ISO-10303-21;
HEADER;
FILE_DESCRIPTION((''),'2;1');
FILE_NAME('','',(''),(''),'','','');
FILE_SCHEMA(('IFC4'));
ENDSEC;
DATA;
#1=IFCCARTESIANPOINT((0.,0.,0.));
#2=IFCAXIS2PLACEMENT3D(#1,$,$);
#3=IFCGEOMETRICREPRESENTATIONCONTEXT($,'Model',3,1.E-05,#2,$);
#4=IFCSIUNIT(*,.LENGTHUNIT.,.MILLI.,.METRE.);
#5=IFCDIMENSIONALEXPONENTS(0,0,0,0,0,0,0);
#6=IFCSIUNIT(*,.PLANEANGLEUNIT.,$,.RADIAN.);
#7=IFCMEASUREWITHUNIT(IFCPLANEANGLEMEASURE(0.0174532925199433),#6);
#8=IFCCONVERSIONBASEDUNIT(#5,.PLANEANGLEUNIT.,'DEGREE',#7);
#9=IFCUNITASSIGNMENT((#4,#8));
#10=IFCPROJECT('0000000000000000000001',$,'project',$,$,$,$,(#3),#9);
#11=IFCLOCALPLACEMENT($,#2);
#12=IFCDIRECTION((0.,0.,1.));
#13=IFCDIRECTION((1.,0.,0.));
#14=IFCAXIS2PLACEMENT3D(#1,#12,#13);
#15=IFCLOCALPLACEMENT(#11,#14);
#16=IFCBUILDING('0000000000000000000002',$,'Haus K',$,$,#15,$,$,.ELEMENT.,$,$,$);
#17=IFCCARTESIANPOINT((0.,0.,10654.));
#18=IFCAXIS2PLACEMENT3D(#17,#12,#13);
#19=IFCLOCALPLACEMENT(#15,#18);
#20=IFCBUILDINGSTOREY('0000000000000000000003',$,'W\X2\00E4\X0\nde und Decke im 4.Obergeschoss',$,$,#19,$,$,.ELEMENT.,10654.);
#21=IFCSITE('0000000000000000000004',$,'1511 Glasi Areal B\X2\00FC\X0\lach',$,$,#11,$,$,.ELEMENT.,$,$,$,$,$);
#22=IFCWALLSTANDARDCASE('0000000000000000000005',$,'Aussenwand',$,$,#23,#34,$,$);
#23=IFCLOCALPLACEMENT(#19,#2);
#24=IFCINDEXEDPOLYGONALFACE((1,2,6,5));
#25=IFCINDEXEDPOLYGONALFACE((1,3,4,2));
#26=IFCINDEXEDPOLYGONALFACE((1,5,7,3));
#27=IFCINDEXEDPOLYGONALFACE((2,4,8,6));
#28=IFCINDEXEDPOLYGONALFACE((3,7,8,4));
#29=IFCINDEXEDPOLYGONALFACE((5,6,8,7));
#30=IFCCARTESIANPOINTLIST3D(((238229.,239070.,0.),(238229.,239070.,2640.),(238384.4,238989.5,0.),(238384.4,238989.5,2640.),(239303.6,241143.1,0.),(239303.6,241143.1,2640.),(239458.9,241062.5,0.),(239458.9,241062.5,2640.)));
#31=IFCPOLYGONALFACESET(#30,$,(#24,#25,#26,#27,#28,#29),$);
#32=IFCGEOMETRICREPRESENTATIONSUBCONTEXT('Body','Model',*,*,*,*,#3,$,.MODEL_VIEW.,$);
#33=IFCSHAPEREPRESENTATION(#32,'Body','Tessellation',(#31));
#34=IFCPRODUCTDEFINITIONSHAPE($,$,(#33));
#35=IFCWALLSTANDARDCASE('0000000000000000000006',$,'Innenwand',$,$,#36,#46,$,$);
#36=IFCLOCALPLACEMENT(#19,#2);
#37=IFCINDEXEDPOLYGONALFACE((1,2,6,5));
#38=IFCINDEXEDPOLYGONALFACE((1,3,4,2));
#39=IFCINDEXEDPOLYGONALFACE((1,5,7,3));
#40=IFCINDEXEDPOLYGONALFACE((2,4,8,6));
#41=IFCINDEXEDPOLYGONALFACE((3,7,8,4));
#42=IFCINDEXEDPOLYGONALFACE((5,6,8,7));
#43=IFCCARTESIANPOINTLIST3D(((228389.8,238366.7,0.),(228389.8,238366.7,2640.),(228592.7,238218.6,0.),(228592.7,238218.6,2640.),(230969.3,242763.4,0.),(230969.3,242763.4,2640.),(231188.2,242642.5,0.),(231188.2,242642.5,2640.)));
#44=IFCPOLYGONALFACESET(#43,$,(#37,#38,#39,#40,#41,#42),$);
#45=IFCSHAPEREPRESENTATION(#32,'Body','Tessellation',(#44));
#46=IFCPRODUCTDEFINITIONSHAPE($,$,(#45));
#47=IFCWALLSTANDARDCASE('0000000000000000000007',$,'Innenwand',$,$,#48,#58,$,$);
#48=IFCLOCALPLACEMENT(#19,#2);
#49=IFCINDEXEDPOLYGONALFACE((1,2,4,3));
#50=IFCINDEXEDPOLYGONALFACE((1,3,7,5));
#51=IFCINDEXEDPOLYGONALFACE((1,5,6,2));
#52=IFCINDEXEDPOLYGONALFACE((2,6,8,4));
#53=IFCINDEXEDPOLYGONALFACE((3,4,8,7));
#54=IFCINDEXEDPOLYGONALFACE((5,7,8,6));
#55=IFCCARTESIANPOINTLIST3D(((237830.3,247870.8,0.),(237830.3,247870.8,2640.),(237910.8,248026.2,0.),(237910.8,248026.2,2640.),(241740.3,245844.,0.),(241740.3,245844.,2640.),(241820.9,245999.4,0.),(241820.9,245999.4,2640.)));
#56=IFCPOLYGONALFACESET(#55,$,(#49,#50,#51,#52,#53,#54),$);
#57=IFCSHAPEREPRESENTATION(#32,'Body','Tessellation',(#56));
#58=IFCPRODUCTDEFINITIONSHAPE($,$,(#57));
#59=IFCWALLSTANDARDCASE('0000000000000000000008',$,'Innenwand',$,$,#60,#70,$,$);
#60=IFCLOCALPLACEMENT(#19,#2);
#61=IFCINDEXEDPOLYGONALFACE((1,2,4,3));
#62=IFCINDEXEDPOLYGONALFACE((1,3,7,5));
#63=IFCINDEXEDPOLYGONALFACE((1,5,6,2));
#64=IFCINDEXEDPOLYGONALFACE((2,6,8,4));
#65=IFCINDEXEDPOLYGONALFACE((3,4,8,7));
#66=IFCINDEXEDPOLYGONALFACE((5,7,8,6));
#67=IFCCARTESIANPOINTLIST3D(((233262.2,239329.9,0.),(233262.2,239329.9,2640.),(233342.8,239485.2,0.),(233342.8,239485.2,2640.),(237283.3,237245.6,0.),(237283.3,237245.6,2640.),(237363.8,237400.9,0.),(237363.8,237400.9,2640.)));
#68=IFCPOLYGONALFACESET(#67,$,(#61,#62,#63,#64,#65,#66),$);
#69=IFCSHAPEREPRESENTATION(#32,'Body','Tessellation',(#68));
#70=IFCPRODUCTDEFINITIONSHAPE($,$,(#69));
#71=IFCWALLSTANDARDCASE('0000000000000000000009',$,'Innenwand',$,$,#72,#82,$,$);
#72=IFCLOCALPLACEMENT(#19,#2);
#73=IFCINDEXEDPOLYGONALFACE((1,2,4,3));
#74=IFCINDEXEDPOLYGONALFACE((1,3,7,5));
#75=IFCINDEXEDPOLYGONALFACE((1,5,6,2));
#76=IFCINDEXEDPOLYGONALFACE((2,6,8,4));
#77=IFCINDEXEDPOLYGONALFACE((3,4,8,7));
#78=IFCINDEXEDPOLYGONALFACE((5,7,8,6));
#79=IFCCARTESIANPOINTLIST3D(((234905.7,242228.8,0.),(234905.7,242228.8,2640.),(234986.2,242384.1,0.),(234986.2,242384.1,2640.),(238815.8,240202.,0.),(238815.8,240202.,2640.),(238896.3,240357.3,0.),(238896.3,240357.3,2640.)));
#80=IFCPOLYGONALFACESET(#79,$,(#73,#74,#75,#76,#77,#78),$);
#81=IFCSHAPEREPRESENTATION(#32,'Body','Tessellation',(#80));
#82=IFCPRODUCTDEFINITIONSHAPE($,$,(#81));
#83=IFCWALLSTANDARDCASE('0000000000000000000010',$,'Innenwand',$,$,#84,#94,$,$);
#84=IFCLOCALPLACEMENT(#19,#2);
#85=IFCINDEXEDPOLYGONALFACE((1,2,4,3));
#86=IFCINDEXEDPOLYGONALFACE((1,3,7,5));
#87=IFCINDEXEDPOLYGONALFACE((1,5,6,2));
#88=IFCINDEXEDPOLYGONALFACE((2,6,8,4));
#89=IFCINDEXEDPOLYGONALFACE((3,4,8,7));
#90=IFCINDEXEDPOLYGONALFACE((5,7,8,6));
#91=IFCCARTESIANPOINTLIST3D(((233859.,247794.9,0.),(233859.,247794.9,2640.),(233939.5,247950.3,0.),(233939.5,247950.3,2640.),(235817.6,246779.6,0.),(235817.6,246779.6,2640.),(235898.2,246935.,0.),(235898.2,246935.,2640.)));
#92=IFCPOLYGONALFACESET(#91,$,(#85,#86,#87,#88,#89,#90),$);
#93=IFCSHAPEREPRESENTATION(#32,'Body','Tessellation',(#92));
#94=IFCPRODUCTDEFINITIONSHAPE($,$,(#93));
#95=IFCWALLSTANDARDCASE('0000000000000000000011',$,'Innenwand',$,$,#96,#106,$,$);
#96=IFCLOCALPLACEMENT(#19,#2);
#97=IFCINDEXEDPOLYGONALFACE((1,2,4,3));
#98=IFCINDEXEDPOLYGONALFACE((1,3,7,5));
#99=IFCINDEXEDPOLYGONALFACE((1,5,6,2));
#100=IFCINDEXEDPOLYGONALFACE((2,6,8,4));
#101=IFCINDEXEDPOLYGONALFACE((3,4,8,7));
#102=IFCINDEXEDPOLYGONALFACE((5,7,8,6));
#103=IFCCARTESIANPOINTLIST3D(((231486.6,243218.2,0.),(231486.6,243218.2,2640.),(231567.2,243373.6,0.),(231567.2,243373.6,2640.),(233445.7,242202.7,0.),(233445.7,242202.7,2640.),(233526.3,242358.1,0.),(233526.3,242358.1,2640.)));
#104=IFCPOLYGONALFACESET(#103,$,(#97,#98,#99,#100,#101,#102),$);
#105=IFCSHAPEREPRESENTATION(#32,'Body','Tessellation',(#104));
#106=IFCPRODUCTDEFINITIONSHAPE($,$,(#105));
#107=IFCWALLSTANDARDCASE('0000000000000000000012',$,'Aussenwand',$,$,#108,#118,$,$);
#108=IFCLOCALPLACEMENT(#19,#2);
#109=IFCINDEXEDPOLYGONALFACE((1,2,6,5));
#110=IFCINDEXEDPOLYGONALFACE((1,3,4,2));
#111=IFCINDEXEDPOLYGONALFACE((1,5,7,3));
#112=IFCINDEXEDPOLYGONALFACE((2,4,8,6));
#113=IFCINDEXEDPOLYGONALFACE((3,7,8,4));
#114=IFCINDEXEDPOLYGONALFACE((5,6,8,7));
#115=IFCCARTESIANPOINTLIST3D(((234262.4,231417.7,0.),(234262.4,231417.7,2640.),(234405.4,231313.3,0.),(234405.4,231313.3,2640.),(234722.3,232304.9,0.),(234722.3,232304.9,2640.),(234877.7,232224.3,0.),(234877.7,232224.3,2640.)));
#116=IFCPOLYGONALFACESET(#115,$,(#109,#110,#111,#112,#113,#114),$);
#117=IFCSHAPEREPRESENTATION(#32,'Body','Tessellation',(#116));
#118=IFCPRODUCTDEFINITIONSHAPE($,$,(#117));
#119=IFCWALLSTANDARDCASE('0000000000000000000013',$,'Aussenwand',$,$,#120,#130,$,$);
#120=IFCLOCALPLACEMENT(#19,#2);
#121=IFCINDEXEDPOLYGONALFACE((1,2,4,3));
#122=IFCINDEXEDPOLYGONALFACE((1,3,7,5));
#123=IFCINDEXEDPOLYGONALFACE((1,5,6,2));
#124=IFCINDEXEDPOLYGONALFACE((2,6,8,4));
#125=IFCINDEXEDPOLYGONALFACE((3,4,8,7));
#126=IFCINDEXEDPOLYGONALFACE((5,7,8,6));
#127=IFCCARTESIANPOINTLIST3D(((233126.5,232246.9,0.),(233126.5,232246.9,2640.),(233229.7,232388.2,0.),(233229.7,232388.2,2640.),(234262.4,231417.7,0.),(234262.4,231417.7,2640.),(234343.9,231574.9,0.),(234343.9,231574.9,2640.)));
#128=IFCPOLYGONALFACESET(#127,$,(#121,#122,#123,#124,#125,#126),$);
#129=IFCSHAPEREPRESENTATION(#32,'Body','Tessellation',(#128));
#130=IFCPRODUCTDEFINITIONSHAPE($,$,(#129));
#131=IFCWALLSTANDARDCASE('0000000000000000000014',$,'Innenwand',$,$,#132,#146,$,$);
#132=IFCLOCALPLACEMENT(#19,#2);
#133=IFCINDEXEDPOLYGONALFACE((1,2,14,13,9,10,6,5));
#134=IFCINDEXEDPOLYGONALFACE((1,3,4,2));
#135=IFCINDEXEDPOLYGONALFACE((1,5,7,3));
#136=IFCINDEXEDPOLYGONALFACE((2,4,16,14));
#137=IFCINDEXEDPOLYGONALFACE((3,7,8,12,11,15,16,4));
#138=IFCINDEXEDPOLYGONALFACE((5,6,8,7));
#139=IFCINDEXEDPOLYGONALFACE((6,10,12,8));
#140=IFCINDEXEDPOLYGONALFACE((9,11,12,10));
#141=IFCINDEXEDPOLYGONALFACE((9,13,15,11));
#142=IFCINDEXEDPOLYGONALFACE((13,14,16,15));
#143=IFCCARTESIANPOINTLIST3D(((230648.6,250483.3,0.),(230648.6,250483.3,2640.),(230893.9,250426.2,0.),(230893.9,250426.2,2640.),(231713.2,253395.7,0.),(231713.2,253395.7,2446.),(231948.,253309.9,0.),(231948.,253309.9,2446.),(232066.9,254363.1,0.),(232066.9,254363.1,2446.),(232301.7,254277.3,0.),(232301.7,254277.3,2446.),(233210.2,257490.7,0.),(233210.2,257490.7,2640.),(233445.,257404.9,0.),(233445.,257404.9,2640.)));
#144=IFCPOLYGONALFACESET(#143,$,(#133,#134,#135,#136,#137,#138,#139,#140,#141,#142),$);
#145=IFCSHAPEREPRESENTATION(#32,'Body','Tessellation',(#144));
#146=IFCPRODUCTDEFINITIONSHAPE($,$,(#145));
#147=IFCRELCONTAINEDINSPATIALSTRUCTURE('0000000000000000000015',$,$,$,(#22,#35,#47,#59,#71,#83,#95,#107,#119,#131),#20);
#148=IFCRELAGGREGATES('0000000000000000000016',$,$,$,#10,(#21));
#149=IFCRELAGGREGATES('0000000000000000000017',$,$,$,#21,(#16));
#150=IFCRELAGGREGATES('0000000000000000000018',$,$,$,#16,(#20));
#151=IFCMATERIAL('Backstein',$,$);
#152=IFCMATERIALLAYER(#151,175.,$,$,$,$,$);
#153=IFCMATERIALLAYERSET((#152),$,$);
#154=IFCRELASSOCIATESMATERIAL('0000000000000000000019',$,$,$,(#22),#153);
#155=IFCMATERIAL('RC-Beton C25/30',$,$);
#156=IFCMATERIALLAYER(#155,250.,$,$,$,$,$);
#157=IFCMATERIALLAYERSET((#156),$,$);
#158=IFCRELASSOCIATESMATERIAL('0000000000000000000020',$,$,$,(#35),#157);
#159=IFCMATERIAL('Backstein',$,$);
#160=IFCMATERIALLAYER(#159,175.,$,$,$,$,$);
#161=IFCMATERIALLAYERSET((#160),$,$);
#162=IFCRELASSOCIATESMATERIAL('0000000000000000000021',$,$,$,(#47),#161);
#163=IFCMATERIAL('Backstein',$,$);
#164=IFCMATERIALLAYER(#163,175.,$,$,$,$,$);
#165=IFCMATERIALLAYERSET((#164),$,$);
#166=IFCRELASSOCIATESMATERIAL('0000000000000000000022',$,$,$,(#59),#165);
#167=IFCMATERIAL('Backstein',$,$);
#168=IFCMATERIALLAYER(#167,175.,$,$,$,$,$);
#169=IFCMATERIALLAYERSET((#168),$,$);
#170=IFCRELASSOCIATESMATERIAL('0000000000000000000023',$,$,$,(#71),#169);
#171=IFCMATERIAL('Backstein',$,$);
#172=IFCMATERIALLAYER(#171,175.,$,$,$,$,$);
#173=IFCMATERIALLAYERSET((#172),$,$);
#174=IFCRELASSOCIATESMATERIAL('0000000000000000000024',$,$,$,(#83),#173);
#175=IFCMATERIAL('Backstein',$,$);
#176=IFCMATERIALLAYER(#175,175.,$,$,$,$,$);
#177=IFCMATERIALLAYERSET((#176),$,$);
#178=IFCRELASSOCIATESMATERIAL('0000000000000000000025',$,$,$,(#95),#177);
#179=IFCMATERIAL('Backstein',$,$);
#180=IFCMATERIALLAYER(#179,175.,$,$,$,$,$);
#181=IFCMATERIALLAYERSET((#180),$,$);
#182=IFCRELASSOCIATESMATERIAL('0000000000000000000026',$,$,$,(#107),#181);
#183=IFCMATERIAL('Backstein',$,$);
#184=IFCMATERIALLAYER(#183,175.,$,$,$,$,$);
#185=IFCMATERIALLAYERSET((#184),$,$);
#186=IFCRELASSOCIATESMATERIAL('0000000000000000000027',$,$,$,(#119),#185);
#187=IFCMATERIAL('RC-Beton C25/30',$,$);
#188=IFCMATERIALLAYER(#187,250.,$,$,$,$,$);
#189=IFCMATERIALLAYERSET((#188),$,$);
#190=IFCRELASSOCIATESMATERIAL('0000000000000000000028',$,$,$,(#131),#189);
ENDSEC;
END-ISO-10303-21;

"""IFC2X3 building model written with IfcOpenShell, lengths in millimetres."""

from ifc_helpers import new_model, entity, si_unit, converted_unit, frame, frame_2d, origin, origin_with_axes, place, context, subcontext, project, spatial, polyline, rectangle, outline, extrude, material, layer, layer_set, layer_usage, element, save


model = new_model("IFC2X3")

# Units and contexts
model_context = context("Model", 3, precision=1e-05, world=origin())
body_context = subcontext(model_context, "Body", "Model", "MODEL_VIEW")
ifc_project = project(units=[si_unit("LENGTHUNIT", "METRE", prefix="MILLI"), converted_unit("PLANEANGLEUNIT", "DEGREE", entity("IfcPlaneAngleMeasure", 0.0174532925199433), si_unit("PLANEANGLEUNIT", "RADIAN"), dimensions=[0, 0, 0, 0, 0, 0, 0])], contexts=[model_context])

# Site, building, storey
site_placement = place(None, origin())
site = spatial("IfcSite", under=ifc_project, at=site_placement, Name="1511 Glasi Areal Bülach", CompositionType="ELEMENT")
building_placement = place(site_placement, origin_with_axes())
building = spatial("IfcBuilding", under=site, at=building_placement, Name="Haus K", CompositionType="ELEMENT")
storey_placement = place(building_placement, frame((0.0, 0.0, 10654.0), z_axis=(0.0, 0.0, 1.0), x_axis=(1.0, 0.0, 0.0)))
storey = spatial("IfcBuildingStorey", under=building, at=storey_placement, Name="Wände und Decke im 4.Obergeschoss", CompositionType="ELEMENT", Elevation=10654.0)

# Walls
ifc_material_1 = material(Name="Backstein")
ifc_layer_1 = layer(ifc_material_1, 175.0)
ifc_layer_set_1 = layer_set([ifc_layer_1])
ifc_layer_usage_1 = layer_usage(ifc_layer_set_1, "AXIS2", "POSITIVE", 0.0)
wall_1_placement = place(storey_placement, frame((238384.4, 238989.5, 0.0), z_axis=(0.0, 0.0, 1.0), x_axis=(0.4602, 0.887815, 0.0)))
element("IfcWallStandardCase", 1, at=wall_1_placement, inside=storey, material=ifc_layer_usage_1, Name="Aussenwand", context=body_context, shape_type="SweptSolid", body=[
    extrude(rectangle(XDim=2335.0, YDim=175.0, at=frame_2d((1167.5, 87.5), x_axis=(1.0, 0.0))), origin_with_axes(), (0.0, 0.0, 1.0), 2640.0),
])
ifc_material_2 = material(Name="RC-Beton C25/30")
ifc_layer_2 = layer(ifc_material_2, 250.0)
ifc_layer_set_2 = layer_set([ifc_layer_2])
ifc_layer_usage_2 = layer_usage(ifc_layer_set_2, "AXIS2", "POSITIVE", 0.0)
wall_2_placement = place(storey_placement, frame((230969.3, 242763.4, 0.0), z_axis=(0.0, 0.0, 1.0), x_axis=(-0.506034, -0.862514, 0.0)))
element("IfcWallStandardCase", 2, at=wall_2_placement, inside=storey, material=ifc_layer_usage_2, Name="Innenwand", context=body_context, shape_type="SweptSolid", body=[
    extrude(outline(polyline([(0.0, 0.0), (5097.5, 0.0), (5122.5, 250.0), (-6.5, 250.0), (0.0, 0.0)])), origin_with_axes(), (0.0, 0.0, 1.0), 2640.0),
])
ifc_material_3 = material(Name="Backstein")
ifc_layer_3 = layer(ifc_material_3, 175.0)
ifc_layer_set_3 = layer_set([ifc_layer_3])
ifc_layer_usage_3 = layer_usage(ifc_layer_set_3, "AXIS2", "POSITIVE", 0.0)
wall_3_placement = place(storey_placement, frame((241820.9, 245999.4, 0.0), z_axis=(0.0, 0.0, 1.0), x_axis=(-0.887815, 0.4602, 0.0)))
element("IfcWallStandardCase", 3, at=wall_3_placement, inside=storey, material=ifc_layer_usage_3, Name="Innenwand", context=body_context, shape_type="SweptSolid", body=[
    extrude(rectangle(XDim=4404.2, YDim=175.0, at=frame_2d((2202.1, 87.5), x_axis=(1.0, 0.0))), origin_with_axes(), (0.0, 0.0, 1.0), 2640.0),
])
ifc_material_4 = material(Name="Backstein")
ifc_layer_4 = layer(ifc_material_4, 175.0)
ifc_layer_set_4 = layer_set([ifc_layer_4])
ifc_layer_usage_4 = layer_usage(ifc_layer_set_4, "AXIS2", "POSITIVE", 0.0)
wall_4_placement = place(storey_placement, frame((233262.2, 239329.9, 0.0), z_axis=(0.0, 0.0, 1.0), x_axis=(0.887815, -0.4602, 0.0)))
element("IfcWallStandardCase", 4, at=wall_4_placement, inside=storey, material=ifc_layer_usage_4, Name="Innenwand", context=body_context, shape_type="SweptSolid", body=[
    extrude(rectangle(XDim=4529.2, YDim=175.0, at=frame_2d((2264.6, 87.5), x_axis=(1.0, 0.0))), origin_with_axes(), (0.0, 0.0, 1.0), 2640.0),
])
ifc_material_5 = material(Name="Backstein")
ifc_layer_5 = layer(ifc_material_5, 175.0)
ifc_layer_set_5 = layer_set([ifc_layer_5])
ifc_layer_usage_5 = layer_usage(ifc_layer_set_5, "AXIS2", "POSITIVE", 0.0)
wall_5_placement = place(storey_placement, frame((238896.3, 240357.3, 0.0), z_axis=(0.0, 0.0, 1.0), x_axis=(-0.887815, 0.4602, 0.0)))
element("IfcWallStandardCase", 5, at=wall_5_placement, inside=storey, material=ifc_layer_usage_5, Name="Innenwand", context=body_context, shape_type="SweptSolid", body=[
    extrude(rectangle(XDim=4404.2, YDim=175.0, at=frame_2d((2202.1, 87.5), x_axis=(1.0, 0.0))), origin_with_axes(), (0.0, 0.0, 1.0), 2640.0),
])
ifc_material_6 = material(Name="Backstein")
ifc_layer_6 = layer(ifc_material_6, 175.0)
ifc_layer_set_6 = layer_set([ifc_layer_6])
ifc_layer_usage_6 = layer_usage(ifc_layer_set_6, "AXIS2", "POSITIVE", 0.0)
wall_6_placement = place(storey_placement, frame((235898.2, 246935.0, 0.0), z_axis=(0.0, 0.0, 1.0), x_axis=(-0.887815, 0.4602, 0.0)))
element("IfcWallStandardCase", 6, at=wall_6_placement, inside=storey, material=ifc_layer_usage_6, Name="Innenwand", context=body_context, shape_type="SweptSolid", body=[
    extrude(rectangle(XDim=2206.2, YDim=175.0, at=frame_2d((1103.1, 87.5), x_axis=(1.0, 0.0))), origin_with_axes(), (0.0, 0.0, 1.0), 2640.0),
])
ifc_material_7 = material(Name="Backstein")
ifc_layer_7 = layer(ifc_material_7, 175.0)
ifc_layer_set_7 = layer_set([ifc_layer_7])
ifc_layer_usage_7 = layer_usage(ifc_layer_set_7, "AXIS2", "POSITIVE", 0.0)
wall_7_placement = place(storey_placement, frame((233526.3, 242358.1, 0.0), z_axis=(0.0, 0.0, 1.0), x_axis=(-0.887815, 0.4602, 0.0)))
element("IfcWallStandardCase", 7, at=wall_7_placement, inside=storey, material=ifc_layer_usage_7, Name="Innenwand", context=body_context, shape_type="SweptSolid", body=[
    extrude(rectangle(XDim=2206.6, YDim=175.0, at=frame_2d((1103.3, 87.5), x_axis=(1.0, 0.0))), origin_with_axes(), (0.0, 0.0, 1.0), 2640.0),
])
ifc_material_8 = material(Name="Backstein")
ifc_layer_8 = layer(ifc_material_8, 175.0)
ifc_layer_set_8 = layer_set([ifc_layer_8])
ifc_layer_usage_8 = layer_usage(ifc_layer_set_8, "AXIS2", "POSITIVE", 0.0)
wall_8_placement = place(storey_placement, frame((234405.4, 231313.3, 0.0), z_axis=(0.0, 0.0, 1.0), x_axis=(0.4602, 0.887815, 0.0)))
element("IfcWallStandardCase", 8, at=wall_8_placement, inside=storey, material=ifc_layer_usage_8, Name="Aussenwand", context=body_context, shape_type="SweptSolid", body=[
    extrude(outline(polyline([(0.0, 0.0), (1026.2, 0.0), (1026.2, 175.0), (26.9, 175.0), (0.0, 0.0)])), origin_with_axes(), (0.0, 0.0, 1.0), 2640.0),
])
ifc_material_9 = material(Name="Backstein")
ifc_layer_9 = layer(ifc_material_9, 175.0)
ifc_layer_set_9 = layer_set([ifc_layer_9])
ifc_layer_usage_9 = layer_usage(ifc_layer_set_9, "AXIS2", "POSITIVE", 0.0)
wall_9_placement = place(storey_placement, frame((233126.5, 232246.9, 0.0), z_axis=(0.0, 0.0, 1.0), x_axis=(0.807681, -0.589619, 0.0)))
element("IfcWallStandardCase", 9, at=wall_9_placement, inside=storey, material=ifc_layer_usage_9, Name="Aussenwand", context=body_context, shape_type="SweptSolid", body=[
    extrude(outline(polyline([(0.0, 0.0), (1406.3, 0.0), (1379.5, 175.0), (0.0, 175.0), (0.0, 0.0)])), origin_with_axes(), (0.0, 0.0, 1.0), 2640.0),
])

# Wall, opening
ifc_material_10 = material(Name="RC-Beton C25/30")
ifc_layer_10 = layer(ifc_material_10, 250.0)
ifc_layer_set_10 = layer_set([ifc_layer_10])
ifc_layer_usage_10 = layer_usage(ifc_layer_set_10, "AXIS2", "POSITIVE", 0.0)
wall_10_placement = place(storey_placement, frame((230893.9, 250426.2, 0.0), z_axis=(0.0, 0.0, 1.0), x_axis=(0.343332, 0.939214, 0.0)))
wall_10 = element("IfcWallStandardCase", 10, at=wall_10_placement, inside=storey, material=ifc_layer_usage_10, Name="Innenwand", context=body_context, shape_type="SweptSolid", body=[
    extrude(outline(polyline([(0.0, 0.0), (7430.3, 0.0), (7430.3, 250.0), (-30.6, 250.0), (0.0, 0.0)])), origin_with_axes(), (0.0, 0.0, 1.0), 2640.0),
])
opening_placement = place(wall_10_placement, frame((3070.3, 0.0, 0.0), z_axis=(0.0, 1.0, 0.0), x_axis=(0.0, 0.0, 1.0)))
element("IfcOpeningElement", 11, at=opening_placement, cuts=wall_10, ObjectType="Opening", context=body_context, shape_type="SweptSolid", body=[
    extrude(rectangle(XDim=2446.0, YDim=1030.0, at=frame_2d((1223.0, 515.0), x_axis=(1.0, 0.0))), origin_with_axes(), (0.0, 0.0, 1.0), 250.0),
])

save(model, "model.ifc")
